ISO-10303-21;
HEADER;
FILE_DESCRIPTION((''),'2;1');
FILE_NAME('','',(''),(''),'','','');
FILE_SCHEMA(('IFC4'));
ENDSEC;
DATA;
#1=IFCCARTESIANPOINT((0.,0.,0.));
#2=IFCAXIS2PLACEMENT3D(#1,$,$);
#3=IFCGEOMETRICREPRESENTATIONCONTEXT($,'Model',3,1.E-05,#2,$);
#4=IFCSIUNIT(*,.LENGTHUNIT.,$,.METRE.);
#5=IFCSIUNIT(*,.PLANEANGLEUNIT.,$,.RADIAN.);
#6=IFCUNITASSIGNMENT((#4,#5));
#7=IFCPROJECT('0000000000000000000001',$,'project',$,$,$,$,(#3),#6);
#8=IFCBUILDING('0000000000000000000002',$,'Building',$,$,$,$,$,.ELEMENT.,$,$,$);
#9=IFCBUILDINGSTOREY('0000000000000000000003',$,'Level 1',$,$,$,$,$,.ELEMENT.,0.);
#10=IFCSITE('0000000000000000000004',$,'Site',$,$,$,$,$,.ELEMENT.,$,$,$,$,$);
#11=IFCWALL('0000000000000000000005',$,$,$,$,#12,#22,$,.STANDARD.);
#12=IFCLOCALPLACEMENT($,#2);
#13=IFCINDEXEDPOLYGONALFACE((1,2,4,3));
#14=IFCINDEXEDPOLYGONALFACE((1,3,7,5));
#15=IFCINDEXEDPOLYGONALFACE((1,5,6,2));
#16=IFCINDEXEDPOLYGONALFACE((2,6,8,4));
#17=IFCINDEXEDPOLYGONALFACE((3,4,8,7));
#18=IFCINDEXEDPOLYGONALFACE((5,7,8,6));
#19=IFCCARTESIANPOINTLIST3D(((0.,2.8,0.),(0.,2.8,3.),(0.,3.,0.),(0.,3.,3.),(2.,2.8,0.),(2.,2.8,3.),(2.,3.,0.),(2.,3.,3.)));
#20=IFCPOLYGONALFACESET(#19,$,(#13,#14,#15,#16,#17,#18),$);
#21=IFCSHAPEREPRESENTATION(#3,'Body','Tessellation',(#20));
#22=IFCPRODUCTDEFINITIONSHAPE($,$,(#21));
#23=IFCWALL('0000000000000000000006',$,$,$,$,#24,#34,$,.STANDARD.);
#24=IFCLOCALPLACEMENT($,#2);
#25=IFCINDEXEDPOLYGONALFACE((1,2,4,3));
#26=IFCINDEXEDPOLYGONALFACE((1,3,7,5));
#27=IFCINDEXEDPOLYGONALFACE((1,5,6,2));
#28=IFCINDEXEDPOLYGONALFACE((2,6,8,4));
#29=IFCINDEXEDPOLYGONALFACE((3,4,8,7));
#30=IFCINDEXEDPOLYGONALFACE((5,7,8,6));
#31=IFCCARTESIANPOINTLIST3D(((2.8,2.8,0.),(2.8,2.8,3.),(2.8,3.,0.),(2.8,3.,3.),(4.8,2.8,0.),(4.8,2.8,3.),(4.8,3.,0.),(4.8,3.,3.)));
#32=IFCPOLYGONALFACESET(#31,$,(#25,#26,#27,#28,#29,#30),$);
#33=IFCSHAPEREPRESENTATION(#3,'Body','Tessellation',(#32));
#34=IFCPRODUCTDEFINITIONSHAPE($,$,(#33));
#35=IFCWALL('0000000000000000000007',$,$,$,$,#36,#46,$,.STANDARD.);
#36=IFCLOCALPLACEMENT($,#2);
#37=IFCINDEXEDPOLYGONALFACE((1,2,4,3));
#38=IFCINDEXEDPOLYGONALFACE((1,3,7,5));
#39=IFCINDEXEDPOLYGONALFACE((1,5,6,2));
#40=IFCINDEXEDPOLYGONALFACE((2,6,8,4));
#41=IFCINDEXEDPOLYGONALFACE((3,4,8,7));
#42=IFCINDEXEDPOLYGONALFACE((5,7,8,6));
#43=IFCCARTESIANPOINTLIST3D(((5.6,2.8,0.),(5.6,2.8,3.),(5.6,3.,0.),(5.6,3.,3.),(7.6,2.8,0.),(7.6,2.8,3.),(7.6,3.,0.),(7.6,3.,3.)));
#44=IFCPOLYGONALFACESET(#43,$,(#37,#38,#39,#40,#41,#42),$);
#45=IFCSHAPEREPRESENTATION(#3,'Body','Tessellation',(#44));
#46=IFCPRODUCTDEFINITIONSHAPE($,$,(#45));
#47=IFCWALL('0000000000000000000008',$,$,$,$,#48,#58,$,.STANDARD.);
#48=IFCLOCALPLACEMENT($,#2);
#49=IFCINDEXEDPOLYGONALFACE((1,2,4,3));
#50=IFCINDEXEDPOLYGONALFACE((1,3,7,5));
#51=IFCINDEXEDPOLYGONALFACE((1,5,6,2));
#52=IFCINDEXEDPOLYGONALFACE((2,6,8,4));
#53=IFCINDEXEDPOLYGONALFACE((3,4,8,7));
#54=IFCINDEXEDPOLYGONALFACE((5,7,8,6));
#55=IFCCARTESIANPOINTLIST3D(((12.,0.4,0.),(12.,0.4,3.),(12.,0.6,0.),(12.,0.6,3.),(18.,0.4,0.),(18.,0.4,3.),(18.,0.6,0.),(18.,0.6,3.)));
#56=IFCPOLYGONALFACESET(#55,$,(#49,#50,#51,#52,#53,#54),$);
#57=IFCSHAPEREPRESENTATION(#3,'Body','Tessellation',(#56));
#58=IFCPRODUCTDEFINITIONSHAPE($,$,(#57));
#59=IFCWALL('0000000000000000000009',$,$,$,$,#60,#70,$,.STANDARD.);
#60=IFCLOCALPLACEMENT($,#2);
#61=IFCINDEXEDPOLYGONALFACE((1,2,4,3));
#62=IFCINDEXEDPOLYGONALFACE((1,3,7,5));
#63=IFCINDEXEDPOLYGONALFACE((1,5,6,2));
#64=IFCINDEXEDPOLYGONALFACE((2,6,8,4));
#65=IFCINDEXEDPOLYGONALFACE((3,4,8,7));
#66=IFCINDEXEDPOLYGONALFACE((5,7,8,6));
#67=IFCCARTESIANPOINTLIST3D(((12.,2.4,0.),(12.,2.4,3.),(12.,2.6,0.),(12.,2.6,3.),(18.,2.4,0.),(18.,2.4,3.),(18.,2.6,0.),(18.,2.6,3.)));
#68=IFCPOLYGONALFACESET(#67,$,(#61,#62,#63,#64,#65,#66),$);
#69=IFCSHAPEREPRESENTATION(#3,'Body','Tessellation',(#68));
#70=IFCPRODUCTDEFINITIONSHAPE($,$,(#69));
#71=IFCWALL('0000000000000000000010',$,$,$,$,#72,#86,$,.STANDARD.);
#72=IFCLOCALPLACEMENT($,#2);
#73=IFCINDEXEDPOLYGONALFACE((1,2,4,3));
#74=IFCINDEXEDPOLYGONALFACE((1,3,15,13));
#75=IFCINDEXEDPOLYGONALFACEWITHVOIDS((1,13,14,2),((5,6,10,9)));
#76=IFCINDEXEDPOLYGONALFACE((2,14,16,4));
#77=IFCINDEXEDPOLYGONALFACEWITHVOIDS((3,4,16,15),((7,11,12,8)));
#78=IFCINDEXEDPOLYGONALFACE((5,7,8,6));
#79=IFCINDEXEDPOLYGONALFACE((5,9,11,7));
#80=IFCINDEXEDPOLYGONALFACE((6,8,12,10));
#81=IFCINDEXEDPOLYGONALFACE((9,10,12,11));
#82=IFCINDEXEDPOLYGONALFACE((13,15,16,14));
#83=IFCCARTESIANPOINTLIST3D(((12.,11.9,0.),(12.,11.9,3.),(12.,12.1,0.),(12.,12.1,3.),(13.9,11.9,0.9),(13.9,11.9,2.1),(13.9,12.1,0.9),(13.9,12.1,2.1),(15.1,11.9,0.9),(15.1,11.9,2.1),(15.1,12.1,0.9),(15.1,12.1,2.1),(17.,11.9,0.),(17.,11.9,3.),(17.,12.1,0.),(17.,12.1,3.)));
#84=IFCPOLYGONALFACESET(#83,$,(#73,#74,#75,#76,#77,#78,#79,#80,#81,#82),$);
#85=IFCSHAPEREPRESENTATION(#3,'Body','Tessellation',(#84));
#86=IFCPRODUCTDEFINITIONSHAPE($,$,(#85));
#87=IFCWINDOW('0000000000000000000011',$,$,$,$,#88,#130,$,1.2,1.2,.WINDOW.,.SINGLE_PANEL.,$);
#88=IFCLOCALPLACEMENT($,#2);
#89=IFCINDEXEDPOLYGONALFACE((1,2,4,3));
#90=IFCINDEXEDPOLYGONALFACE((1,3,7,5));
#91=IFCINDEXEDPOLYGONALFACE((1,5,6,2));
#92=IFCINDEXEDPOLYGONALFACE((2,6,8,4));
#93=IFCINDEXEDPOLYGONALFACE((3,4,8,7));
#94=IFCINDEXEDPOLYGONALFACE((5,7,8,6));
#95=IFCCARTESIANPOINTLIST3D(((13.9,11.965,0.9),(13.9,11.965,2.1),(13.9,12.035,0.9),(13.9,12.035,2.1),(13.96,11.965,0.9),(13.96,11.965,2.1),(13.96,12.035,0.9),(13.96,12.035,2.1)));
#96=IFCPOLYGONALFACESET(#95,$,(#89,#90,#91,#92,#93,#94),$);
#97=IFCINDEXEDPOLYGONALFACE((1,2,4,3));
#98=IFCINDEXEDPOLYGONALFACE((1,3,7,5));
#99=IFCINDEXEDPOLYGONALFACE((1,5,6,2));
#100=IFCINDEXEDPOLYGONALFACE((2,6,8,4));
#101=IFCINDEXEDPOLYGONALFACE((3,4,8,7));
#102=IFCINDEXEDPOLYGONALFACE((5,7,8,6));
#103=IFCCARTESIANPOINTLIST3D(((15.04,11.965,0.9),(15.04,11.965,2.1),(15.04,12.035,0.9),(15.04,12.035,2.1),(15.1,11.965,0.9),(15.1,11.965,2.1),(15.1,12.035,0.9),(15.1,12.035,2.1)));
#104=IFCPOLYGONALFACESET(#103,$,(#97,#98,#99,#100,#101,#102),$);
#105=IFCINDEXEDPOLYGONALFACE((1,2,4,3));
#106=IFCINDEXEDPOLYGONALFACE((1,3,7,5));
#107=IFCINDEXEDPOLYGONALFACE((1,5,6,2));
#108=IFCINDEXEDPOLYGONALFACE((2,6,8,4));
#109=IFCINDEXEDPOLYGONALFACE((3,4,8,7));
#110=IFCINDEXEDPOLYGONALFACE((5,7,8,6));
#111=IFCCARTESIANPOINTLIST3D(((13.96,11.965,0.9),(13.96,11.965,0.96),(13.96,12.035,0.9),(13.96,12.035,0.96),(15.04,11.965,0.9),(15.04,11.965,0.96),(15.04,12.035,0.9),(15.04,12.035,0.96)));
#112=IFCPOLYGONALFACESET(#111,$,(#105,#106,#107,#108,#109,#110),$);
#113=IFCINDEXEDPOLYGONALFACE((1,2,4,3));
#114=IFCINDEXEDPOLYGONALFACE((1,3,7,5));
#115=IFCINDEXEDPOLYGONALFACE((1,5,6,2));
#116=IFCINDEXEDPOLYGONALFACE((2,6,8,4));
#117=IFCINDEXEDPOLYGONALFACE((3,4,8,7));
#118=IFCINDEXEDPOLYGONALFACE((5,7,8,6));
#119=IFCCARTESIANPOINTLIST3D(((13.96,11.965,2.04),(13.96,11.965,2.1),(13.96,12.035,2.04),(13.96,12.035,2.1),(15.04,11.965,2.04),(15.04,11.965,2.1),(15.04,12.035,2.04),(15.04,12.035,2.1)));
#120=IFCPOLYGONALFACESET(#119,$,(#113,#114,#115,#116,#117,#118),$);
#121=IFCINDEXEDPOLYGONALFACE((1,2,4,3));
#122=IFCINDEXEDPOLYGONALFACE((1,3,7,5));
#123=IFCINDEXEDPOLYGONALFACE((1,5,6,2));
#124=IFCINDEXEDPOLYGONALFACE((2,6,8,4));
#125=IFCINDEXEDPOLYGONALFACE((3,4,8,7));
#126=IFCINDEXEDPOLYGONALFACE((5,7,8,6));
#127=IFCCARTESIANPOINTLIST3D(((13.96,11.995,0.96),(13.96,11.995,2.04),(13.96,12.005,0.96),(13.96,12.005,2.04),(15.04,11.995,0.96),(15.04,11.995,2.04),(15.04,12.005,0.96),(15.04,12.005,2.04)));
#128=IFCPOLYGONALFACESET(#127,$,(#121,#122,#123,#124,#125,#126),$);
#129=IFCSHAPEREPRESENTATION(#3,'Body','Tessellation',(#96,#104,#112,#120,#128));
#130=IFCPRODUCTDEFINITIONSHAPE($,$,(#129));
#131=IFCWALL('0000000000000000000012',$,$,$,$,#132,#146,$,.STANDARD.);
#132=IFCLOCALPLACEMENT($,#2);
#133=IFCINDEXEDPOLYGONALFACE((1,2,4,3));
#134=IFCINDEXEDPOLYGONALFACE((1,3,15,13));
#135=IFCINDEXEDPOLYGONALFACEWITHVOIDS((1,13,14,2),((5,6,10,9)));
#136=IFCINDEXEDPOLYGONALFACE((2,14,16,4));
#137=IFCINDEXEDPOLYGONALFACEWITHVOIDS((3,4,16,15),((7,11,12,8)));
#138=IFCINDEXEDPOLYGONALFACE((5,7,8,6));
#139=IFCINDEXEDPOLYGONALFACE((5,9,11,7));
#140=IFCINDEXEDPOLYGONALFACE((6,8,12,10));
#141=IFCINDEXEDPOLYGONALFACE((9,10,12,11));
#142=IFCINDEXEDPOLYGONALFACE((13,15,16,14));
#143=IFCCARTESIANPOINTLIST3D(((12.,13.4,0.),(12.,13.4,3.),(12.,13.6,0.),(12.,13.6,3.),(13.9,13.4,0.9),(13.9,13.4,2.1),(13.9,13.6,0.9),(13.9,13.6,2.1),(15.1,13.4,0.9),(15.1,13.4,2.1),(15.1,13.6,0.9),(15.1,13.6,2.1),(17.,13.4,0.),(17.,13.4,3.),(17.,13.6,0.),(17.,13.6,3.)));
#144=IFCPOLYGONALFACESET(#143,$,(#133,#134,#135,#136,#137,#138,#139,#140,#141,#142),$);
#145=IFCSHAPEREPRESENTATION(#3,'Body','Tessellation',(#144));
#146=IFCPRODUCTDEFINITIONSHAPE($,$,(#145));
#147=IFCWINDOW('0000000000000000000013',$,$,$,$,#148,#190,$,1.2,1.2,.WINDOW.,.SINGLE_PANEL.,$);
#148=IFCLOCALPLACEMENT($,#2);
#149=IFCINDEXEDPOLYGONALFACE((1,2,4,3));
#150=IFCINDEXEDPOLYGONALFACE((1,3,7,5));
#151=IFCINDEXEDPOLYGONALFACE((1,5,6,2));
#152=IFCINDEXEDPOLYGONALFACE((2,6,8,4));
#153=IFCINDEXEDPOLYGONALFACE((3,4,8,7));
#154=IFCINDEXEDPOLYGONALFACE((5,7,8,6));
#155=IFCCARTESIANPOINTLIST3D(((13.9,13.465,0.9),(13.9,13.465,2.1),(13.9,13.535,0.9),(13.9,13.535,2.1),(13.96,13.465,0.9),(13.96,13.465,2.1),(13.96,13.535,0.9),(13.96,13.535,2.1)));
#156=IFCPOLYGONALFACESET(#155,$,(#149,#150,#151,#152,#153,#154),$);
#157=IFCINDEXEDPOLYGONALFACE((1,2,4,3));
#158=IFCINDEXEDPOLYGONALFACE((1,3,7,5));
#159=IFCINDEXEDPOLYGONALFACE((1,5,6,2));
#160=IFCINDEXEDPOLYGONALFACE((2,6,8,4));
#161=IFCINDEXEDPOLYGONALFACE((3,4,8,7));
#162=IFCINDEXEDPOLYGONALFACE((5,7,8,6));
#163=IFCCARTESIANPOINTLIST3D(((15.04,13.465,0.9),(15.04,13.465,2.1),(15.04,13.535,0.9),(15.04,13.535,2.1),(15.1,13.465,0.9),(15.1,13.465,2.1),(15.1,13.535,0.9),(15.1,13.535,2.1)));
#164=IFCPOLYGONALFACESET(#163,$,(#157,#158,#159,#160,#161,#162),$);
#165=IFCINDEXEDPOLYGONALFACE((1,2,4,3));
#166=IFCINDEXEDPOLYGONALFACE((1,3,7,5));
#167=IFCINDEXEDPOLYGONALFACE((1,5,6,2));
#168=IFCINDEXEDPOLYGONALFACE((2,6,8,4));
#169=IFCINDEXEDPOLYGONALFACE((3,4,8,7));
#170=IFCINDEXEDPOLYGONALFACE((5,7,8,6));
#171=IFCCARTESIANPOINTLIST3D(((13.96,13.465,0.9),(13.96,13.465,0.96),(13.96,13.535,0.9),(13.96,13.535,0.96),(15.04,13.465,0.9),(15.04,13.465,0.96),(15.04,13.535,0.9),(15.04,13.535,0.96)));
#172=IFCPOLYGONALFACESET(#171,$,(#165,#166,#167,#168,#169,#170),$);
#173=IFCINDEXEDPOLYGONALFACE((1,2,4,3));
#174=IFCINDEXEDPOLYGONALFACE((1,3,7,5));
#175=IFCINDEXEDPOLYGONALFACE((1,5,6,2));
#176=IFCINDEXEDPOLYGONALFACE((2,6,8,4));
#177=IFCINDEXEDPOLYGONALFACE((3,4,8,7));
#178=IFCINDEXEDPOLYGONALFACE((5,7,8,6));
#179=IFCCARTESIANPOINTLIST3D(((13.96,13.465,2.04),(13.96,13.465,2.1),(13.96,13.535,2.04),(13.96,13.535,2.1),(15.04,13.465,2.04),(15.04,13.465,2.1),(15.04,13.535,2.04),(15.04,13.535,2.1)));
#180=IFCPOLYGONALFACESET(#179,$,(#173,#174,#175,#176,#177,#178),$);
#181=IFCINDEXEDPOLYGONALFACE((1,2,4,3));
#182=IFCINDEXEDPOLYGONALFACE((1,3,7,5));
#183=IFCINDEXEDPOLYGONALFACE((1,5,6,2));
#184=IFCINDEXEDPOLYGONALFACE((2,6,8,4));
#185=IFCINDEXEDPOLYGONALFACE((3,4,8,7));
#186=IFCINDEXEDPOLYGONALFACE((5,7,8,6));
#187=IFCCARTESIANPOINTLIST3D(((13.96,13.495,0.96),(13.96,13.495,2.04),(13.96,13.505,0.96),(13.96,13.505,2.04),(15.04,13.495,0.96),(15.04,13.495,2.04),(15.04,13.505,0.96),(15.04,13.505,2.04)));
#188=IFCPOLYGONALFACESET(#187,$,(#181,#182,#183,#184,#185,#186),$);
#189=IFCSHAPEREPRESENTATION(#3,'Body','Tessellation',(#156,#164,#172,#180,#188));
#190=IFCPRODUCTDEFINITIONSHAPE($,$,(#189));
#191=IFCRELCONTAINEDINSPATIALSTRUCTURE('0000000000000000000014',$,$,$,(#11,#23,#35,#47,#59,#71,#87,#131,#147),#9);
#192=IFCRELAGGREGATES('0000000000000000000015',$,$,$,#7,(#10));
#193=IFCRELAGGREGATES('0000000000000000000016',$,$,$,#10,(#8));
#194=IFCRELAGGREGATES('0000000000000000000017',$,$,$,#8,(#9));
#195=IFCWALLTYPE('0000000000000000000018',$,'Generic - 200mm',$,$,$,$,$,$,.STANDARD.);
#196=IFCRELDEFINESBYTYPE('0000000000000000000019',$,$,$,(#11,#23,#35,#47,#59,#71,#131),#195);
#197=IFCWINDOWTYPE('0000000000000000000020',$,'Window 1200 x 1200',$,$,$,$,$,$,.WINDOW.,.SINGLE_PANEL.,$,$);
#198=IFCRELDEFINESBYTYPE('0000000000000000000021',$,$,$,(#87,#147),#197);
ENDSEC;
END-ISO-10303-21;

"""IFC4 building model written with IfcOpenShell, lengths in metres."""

from ifc_helpers import new_model, si_unit, frame, frame_2d, origin, origin_with_axes, origin_2d, place, context, project, spatial, rectangle, extrude, type_object, element, fill, save


model = new_model("IFC4")

# Units and contexts
model_context = context("Model", 3, precision=1e-05, world=origin())
ifc_project = project(units=[si_unit("LENGTHUNIT", "METRE"), si_unit("PLANEANGLEUNIT", "RADIAN")], contexts=[model_context])

# Site, building, storey
site = spatial("IfcSite", under=ifc_project, Name="Site", CompositionType="ELEMENT")
building = spatial("IfcBuilding", under=site, Name="Building", CompositionType="ELEMENT")
storey = spatial("IfcBuildingStorey", under=building, Name="Level 1", CompositionType="ELEMENT", Elevation=0.0)

# Walls
wall_type = type_object("IfcWallType", Name="Generic - 200mm", PredefinedType="STANDARD")
for number, where, z_axis, x_axis in (
    (1, (0.0, 2.9, 0.0), (0.0, 0.0, 1.0), (1.0, 0.0, 0.0)),
    (2, (2.8, 2.9, 0.0), (0.0, 0.0, 1.0), (1.0, 0.0, 0.0)),
    (3, (5.6, 2.9, 0.0), (0.0, 0.0, 1.0), (1.0, 0.0, 0.0)),
):
    element("IfcWall", number, at=place(None, frame(where, z_axis=z_axis, x_axis=x_axis)), inside=storey, type_object=wall_type, PredefinedType="STANDARD", context=model_context, shape_type="SweptSolid", body=[
        extrude(rectangle(XDim=2.0, YDim=0.2, at=frame_2d((1.0, 0.0))), origin(), (0.0, 0.0, 1.0), 3.0),
    ])
for number, where, z_axis, x_axis in (
    (4, (12.0, 0.5, 0.0), (0.0, 0.0, 1.0), (1.0, 0.0, 0.0)),
    (5, (12.0, 2.5, 0.0), (0.0, 0.0, 1.0), (1.0, 0.0, 0.0)),
):
    element("IfcWall", number, at=place(None, frame(where, z_axis=z_axis, x_axis=x_axis)), inside=storey, type_object=wall_type, PredefinedType="STANDARD", context=model_context, shape_type="SweptSolid", body=[
        extrude(rectangle(XDim=6.0, YDim=0.2, at=frame_2d((3.0, 0.0))), origin(), (0.0, 0.0, 1.0), 3.0),
    ])

# Walls, openings, windows
wall_1_placement = place(None, frame((12.0, 12.0, 0.0), z_axis=(0.0, 0.0, 1.0), x_axis=(1.0, 0.0, 0.0)))
wall_1 = element("IfcWall", 6, at=wall_1_placement, inside=storey, type_object=wall_type, PredefinedType="STANDARD", context=model_context, shape_type="SweptSolid", body=[
    extrude(rectangle(XDim=5.0, YDim=0.2, at=frame_2d((2.5, 0.0))), origin(), (0.0, 0.0, 1.0), 3.0),
])
opening_1_placement = place(wall_1_placement, frame((2.5, 0.0, 0.9), z_axis=(0.0, 0.0, 1.0), x_axis=(1.0, 0.0, 0.0)))
opening_1 = element("IfcOpeningElement", 7, at=opening_1_placement, cuts=wall_1, PredefinedType="OPENING", context=model_context, shape_type="SweptSolid", body=[
    extrude(rectangle(XDim=1.2, YDim=0.202, at=origin_2d()), origin(), (0.0, 0.0, 1.0), 1.2),
])
window_type = type_object("IfcWindowType", Name="Window 1200 x 1200", PartitioningType="SINGLE_PANEL", PredefinedType="WINDOW")
window_1_placement = place(opening_1_placement, origin_with_axes())
window_1 = element("IfcWindow", 8, at=window_1_placement, inside=storey, type_object=window_type, OverallHeight=1.2, OverallWidth=1.2, PartitioningType="SINGLE_PANEL", PredefinedType="WINDOW", context=model_context, shape_type="SweptSolid", body=[
    extrude(rectangle(XDim=0.06, YDim=0.07, at=frame_2d((-0.57, 0.0))), origin(), (0.0, 0.0, 1.0), 1.2),
    extrude(rectangle(XDim=0.06, YDim=0.07, at=frame_2d((0.57, 0.0))), origin(), (0.0, 0.0, 1.0), 1.2),
    extrude(rectangle(XDim=1.08, YDim=0.07, at=origin_2d()), origin(), (0.0, 0.0, 1.0), 0.06),
    extrude(rectangle(XDim=1.08, YDim=0.07, at=origin_2d()), frame((0.0, 0.0, 1.14)), (0.0, 0.0, 1.0), 0.06),
    extrude(rectangle(XDim=1.08, YDim=0.01, at=origin_2d()), frame((0.0, 0.0, 0.06)), (0.0, 0.0, 1.0), 1.08),
])
fill(opening_1, window_1)
wall_2_placement = place(None, frame((12.0, 13.5, 0.0), z_axis=(0.0, 0.0, 1.0), x_axis=(1.0, 0.0, 0.0)))
wall_2 = element("IfcWall", 9, at=wall_2_placement, inside=storey, type_object=wall_type, PredefinedType="STANDARD", context=model_context, shape_type="SweptSolid", body=[
    extrude(rectangle(XDim=5.0, YDim=0.2, at=frame_2d((2.5, 0.0))), origin(), (0.0, 0.0, 1.0), 3.0),
])
opening_2_placement = place(wall_2_placement, frame((2.5, 0.0, 0.9), z_axis=(0.0, 0.0, 1.0), x_axis=(1.0, 0.0, 0.0)))
opening_2 = element("IfcOpeningElement", 10, at=opening_2_placement, cuts=wall_2, PredefinedType="OPENING", context=model_context, shape_type="SweptSolid", body=[
    extrude(rectangle(XDim=1.2, YDim=0.202, at=origin_2d()), origin(), (0.0, 0.0, 1.0), 1.2),
])
window_2_placement = place(opening_2_placement, origin_with_axes())
window_2 = element("IfcWindow", 11, at=window_2_placement, inside=storey, type_object=window_type, OverallHeight=1.2, OverallWidth=1.2, PartitioningType="SINGLE_PANEL", PredefinedType="WINDOW", context=model_context, shape_type="SweptSolid", body=[
    extrude(rectangle(XDim=0.06, YDim=0.07, at=frame_2d((-0.57, 0.0))), origin(), (0.0, 0.0, 1.0), 1.2),
    extrude(rectangle(XDim=0.06, YDim=0.07, at=frame_2d((0.57, 0.0))), origin(), (0.0, 0.0, 1.0), 1.2),
    extrude(rectangle(XDim=1.08, YDim=0.07, at=origin_2d()), origin(), (0.0, 0.0, 1.0), 0.06),
    extrude(rectangle(XDim=1.08, YDim=0.07, at=origin_2d()), frame((0.0, 0.0, 1.14)), (0.0, 0.0, 1.0), 0.06),
    extrude(rectangle(XDim=1.08, YDim=0.01, at=origin_2d()), frame((0.0, 0.0, 0.06)), (0.0, 0.0, 1.0), 1.08),
])
fill(opening_2, window_2)

save(model, "model.ifc")
